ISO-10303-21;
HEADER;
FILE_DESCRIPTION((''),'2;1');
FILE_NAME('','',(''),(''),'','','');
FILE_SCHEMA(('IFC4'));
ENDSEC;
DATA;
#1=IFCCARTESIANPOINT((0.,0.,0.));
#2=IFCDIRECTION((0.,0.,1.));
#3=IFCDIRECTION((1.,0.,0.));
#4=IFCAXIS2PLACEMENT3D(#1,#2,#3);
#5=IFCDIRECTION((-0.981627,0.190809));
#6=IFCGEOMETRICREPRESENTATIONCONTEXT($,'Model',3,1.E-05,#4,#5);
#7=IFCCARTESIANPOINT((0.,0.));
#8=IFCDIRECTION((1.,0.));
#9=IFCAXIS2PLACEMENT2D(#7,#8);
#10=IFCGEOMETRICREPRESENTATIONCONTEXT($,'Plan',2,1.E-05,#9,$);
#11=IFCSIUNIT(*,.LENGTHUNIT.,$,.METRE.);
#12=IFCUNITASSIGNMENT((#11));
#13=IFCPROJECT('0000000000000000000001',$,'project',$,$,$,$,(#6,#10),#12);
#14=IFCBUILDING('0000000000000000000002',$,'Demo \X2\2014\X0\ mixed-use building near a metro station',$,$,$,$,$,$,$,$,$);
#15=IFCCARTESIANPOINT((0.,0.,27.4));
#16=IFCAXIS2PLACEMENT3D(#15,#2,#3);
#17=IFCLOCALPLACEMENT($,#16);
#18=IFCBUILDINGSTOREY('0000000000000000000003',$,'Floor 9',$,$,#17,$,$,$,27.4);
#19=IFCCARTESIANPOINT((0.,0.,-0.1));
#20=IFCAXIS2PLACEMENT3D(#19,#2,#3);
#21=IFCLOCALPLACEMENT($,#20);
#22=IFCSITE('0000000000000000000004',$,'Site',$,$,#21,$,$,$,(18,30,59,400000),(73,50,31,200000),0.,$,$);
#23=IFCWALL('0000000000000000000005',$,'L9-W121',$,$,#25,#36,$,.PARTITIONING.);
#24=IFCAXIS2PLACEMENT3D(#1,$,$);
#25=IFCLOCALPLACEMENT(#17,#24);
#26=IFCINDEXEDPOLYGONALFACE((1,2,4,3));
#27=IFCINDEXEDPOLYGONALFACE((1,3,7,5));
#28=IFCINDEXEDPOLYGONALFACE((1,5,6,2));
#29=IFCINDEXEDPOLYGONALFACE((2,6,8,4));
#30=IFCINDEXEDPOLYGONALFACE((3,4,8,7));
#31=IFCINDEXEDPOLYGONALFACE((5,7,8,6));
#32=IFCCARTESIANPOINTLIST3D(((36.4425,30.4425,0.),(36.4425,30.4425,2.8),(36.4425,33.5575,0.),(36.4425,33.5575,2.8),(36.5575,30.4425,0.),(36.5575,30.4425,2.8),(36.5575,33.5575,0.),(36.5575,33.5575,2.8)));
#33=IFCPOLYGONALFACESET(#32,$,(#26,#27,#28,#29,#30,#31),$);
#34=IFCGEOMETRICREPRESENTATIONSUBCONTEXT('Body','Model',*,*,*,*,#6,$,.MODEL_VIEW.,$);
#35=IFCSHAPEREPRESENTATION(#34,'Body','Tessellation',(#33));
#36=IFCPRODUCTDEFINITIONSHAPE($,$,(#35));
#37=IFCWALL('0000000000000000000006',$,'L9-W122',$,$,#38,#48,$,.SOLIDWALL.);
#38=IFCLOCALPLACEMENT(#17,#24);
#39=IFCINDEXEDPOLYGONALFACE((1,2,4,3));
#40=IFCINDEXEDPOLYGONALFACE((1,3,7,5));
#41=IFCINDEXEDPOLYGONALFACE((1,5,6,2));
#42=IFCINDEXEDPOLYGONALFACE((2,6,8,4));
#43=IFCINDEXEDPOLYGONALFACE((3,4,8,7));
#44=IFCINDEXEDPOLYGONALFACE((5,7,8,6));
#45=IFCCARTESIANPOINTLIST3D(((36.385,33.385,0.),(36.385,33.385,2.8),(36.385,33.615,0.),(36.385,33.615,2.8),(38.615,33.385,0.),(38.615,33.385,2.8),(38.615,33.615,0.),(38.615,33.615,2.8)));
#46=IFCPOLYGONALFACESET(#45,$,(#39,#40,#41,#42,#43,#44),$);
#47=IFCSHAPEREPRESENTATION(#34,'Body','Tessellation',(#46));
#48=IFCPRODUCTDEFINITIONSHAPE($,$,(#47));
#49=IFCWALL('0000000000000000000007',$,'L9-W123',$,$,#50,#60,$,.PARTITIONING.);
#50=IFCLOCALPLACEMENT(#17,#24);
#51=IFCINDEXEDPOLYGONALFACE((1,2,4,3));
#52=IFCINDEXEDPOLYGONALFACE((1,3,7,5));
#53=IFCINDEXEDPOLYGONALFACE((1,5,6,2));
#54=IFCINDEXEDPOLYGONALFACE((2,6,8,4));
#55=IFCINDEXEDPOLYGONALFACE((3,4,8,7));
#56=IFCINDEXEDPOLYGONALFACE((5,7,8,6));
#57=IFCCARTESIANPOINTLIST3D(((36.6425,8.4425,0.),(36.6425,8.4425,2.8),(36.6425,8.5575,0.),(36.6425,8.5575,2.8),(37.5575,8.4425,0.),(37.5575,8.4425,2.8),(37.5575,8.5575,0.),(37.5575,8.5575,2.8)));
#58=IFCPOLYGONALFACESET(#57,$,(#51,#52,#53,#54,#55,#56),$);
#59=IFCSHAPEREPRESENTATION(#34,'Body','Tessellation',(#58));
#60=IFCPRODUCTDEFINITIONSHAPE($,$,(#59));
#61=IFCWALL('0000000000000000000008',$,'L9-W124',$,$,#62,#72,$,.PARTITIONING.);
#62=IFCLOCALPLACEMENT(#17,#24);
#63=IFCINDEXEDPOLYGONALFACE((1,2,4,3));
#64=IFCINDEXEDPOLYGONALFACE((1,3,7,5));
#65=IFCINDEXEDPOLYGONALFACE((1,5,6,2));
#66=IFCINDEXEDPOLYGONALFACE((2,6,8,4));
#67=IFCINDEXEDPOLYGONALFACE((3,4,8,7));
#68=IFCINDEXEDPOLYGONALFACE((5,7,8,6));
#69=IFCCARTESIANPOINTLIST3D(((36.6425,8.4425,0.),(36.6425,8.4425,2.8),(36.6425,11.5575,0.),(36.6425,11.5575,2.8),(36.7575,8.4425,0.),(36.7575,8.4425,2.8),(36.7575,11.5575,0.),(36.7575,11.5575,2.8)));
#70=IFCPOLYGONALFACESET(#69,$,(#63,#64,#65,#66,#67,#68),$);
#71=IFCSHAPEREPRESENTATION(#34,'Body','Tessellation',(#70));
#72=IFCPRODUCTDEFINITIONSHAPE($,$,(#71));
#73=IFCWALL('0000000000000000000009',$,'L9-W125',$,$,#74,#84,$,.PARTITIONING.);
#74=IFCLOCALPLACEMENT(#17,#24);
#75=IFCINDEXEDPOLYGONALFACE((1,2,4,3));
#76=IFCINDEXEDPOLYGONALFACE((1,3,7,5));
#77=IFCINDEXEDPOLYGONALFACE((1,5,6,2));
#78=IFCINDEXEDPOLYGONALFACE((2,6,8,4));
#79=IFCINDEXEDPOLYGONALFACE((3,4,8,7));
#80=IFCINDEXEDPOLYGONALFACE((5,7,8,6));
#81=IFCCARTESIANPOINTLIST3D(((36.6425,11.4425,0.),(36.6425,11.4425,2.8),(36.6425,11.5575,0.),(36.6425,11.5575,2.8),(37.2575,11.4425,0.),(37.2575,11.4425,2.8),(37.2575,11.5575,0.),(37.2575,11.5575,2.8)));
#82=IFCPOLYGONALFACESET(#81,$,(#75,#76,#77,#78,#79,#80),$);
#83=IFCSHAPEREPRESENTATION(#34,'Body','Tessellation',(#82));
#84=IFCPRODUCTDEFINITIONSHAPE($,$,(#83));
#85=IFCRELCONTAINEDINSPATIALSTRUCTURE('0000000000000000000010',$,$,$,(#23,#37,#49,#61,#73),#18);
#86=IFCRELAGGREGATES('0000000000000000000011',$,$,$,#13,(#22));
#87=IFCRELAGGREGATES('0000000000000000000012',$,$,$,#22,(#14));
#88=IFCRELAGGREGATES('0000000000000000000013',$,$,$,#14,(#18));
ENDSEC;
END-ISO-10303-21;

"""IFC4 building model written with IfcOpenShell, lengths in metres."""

from ifc_helpers import new_model, si_unit, direction, frame, origin_with_axes, origin_2d_with_axis, place, context, subcontext, project, spatial, line, indexed_curve, outline, extrude, element, save


model = new_model("IFC4")

# Units and contexts
model_context = context("Model", 3, precision=1e-05, world=origin_with_axes(), true_north=direction((-0.981627, 0.190809)))
plan_context = context("Plan", 2, precision=1e-05, world=origin_2d_with_axis())
body_context = subcontext(model_context, "Body", "Model", "MODEL_VIEW")
ifc_project = project(units=[si_unit("LENGTHUNIT", "METRE")], contexts=[model_context, plan_context])

# Site, building, storey
site_placement = place(None, frame((0.0, 0.0, -0.1), z_axis=(0.0, 0.0, 1.0), x_axis=(1.0, 0.0, 0.0)))
site = spatial("IfcSite", under=ifc_project, at=site_placement, Name="Site", RefLatitude=(18, 30, 59, 400000), RefLongitude=(73, 50, 31, 200000), RefElevation=0.0)
building = spatial("IfcBuilding", under=site, Name="Demo — mixed-use building near a metro station")
storey_placement = place(None, frame((0.0, 0.0, 27.4), z_axis=(0.0, 0.0, 1.0), x_axis=(1.0, 0.0, 0.0)))
storey = spatial("IfcBuildingStorey", under=building, at=storey_placement, Name="Floor 9", Elevation=27.4)

# Walls
wall_1_placement = place(storey_placement, frame((0.0, 0.0, -27.4), z_axis=(0.0, 0.0, 1.0), x_axis=(1.0, 0.0, 0.0)))
element("IfcWall", 1, at=wall_1_placement, inside=storey, Name="L9-W121", PredefinedType="PARTITIONING", context=body_context, shape_type="SweptSolid", body=[
    extrude(outline(indexed_curve([(36.5575, 33.5575), (36.5575, 30.4425), (36.4425, 30.4425), (36.4425, 33.5575)], segments=[line(1, 2, 3, 4, 1)])), frame((0.0, 0.0, 27.4), z_axis=(0.0, 0.0, 1.0), x_axis=(1.0, 0.0, 0.0)), (0.0, 0.0, 1.0), 2.8),
])
wall_2_placement = place(storey_placement, frame((0.0, 0.0, -27.4), z_axis=(0.0, 0.0, 1.0), x_axis=(1.0, 0.0, 0.0)))
element("IfcWall", 2, at=wall_2_placement, inside=storey, Name="L9-W122", PredefinedType="SOLIDWALL", context=body_context, shape_type="SweptSolid", body=[
    extrude(outline(indexed_curve([(38.615, 33.385), (36.385, 33.385), (36.385, 33.615), (38.615, 33.615)], segments=[line(1, 2, 3, 4, 1)])), frame((0.0, 0.0, 27.4), z_axis=(0.0, 0.0, 1.0), x_axis=(1.0, 0.0, 0.0)), (0.0, 0.0, 1.0), 2.8),
])
wall_3_placement = place(storey_placement, frame((0.0, 0.0, -27.4), z_axis=(0.0, 0.0, 1.0), x_axis=(1.0, 0.0, 0.0)))
element("IfcWall", 3, at=wall_3_placement, inside=storey, Name="L9-W123", PredefinedType="PARTITIONING", context=body_context, shape_type="SweptSolid", body=[
    extrude(outline(indexed_curve([(37.5575, 8.4425), (36.6425, 8.4425), (36.6425, 8.5575), (37.5575, 8.5575)], segments=[line(1, 2, 3, 4, 1)])), frame((0.0, 0.0, 27.4), z_axis=(0.0, 0.0, 1.0), x_axis=(1.0, 0.0, 0.0)), (0.0, 0.0, 1.0), 2.8),
])
wall_4_placement = place(storey_placement, frame((0.0, 0.0, -27.4), z_axis=(0.0, 0.0, 1.0), x_axis=(1.0, 0.0, 0.0)))
element("IfcWall", 4, at=wall_4_placement, inside=storey, Name="L9-W124", PredefinedType="PARTITIONING", context=body_context, shape_type="SweptSolid", body=[
    extrude(outline(indexed_curve([(36.7575, 11.5575), (36.7575, 8.4425), (36.6425, 8.4425), (36.6425, 11.5575)], segments=[line(1, 2, 3, 4, 1)])), frame((0.0, 0.0, 27.4), z_axis=(0.0, 0.0, 1.0), x_axis=(1.0, 0.0, 0.0)), (0.0, 0.0, 1.0), 2.8),
])
wall_5_placement = place(storey_placement, frame((0.0, 0.0, -27.4), z_axis=(0.0, 0.0, 1.0), x_axis=(1.0, 0.0, 0.0)))
element("IfcWall", 5, at=wall_5_placement, inside=storey, Name="L9-W125", PredefinedType="PARTITIONING", context=body_context, shape_type="SweptSolid", body=[
    extrude(outline(indexed_curve([(36.6425, 11.5575), (37.2575, 11.5575), (37.2575, 11.4425), (36.6425, 11.4425)], segments=[line(1, 2, 3, 4, 1)])), frame((0.0, 0.0, 27.4), z_axis=(0.0, 0.0, 1.0), x_axis=(1.0, 0.0, 0.0)), (0.0, 0.0, 1.0), 2.8),
])

save(model, "model.ifc")
